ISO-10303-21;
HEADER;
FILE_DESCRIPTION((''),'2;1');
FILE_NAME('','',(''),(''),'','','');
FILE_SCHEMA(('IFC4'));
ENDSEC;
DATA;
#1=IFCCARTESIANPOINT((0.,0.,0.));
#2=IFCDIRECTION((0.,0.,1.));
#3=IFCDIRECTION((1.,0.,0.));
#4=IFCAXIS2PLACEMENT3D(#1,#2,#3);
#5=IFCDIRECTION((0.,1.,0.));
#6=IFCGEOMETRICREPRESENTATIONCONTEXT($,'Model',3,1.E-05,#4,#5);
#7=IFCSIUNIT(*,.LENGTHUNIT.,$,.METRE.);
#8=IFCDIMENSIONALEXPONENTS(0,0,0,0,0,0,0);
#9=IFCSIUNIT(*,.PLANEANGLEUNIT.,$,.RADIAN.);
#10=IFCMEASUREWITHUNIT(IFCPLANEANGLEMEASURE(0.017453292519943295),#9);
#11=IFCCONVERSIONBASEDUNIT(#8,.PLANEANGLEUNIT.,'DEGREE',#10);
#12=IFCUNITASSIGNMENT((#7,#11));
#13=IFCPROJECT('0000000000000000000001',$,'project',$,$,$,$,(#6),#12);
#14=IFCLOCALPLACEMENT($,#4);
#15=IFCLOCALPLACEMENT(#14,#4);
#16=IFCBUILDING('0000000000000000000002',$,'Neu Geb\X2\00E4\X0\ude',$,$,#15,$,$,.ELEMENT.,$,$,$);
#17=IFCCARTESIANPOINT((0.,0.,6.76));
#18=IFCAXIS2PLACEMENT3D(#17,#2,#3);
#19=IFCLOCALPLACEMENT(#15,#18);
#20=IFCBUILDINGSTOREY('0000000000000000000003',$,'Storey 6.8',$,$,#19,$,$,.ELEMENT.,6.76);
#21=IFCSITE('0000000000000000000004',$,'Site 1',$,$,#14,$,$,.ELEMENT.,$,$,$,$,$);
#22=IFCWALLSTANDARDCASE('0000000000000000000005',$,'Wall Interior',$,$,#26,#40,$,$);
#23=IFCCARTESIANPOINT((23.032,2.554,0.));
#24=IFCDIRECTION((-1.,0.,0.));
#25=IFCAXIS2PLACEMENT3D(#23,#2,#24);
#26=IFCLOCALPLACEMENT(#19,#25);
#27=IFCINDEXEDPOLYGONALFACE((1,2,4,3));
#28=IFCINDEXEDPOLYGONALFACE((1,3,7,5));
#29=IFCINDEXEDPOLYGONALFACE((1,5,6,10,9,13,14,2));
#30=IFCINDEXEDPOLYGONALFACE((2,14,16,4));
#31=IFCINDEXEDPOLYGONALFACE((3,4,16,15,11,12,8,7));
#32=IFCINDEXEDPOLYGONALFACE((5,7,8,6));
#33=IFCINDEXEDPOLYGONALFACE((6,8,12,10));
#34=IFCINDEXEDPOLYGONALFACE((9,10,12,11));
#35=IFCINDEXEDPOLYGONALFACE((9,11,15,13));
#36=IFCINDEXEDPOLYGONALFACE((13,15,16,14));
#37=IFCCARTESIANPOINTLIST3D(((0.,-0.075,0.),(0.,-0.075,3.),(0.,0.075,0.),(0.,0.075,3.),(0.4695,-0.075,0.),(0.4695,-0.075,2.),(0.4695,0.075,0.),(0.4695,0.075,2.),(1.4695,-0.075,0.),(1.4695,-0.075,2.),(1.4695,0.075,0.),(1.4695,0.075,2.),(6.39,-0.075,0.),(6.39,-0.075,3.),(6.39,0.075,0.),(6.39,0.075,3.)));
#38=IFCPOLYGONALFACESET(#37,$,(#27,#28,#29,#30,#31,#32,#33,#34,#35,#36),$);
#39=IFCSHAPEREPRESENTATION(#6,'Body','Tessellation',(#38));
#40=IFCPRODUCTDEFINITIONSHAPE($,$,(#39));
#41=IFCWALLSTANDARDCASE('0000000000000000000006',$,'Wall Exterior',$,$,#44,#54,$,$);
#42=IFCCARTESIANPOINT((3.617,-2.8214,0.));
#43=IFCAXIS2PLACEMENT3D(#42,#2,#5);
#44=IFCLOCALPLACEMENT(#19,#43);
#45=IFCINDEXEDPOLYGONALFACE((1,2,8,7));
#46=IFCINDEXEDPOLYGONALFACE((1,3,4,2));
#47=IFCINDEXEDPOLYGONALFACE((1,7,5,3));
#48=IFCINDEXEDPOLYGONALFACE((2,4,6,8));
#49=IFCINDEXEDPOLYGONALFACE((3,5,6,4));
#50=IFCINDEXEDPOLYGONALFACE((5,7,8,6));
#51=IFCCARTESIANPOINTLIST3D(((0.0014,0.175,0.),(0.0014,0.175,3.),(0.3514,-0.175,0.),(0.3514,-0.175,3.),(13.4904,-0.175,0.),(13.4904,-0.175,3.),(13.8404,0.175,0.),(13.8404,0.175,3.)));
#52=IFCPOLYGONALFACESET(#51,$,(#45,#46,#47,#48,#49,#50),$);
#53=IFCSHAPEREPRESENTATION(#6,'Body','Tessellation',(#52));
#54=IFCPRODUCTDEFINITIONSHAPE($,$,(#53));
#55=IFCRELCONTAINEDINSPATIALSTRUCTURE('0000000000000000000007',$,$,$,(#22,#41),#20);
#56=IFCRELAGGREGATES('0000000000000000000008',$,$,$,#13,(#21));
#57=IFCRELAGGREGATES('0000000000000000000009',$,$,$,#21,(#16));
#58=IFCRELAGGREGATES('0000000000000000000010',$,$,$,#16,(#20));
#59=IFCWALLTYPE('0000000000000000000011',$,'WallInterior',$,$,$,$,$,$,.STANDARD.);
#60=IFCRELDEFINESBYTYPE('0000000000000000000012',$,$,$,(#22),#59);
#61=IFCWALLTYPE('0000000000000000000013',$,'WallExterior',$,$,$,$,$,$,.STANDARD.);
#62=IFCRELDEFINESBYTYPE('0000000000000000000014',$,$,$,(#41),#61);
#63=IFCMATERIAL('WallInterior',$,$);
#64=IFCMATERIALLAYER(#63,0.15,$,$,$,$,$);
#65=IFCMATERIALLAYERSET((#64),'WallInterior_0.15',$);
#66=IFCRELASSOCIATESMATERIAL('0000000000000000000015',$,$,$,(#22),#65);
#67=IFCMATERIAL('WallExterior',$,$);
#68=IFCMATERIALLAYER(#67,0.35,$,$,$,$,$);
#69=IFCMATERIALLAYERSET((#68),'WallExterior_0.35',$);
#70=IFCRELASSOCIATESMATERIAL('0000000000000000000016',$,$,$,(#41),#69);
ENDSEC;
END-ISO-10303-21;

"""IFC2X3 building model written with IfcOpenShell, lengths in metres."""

from ifc_helpers import new_model, entity, si_unit, converted_unit, direction, frame, origin_with_axes, place, context, project, spatial, polyline, outline, extrude, material, layer, layer_set, layer_usage, type_object, element, save


model = new_model("IFC2X3")

# Units and contexts
model_context = context("Model", 3, precision=1e-05, world=origin_with_axes(), true_north=direction((0.0, 1.0, 0.0)))
ifc_project = project(units=[si_unit("LENGTHUNIT", "METRE"), converted_unit("PLANEANGLEUNIT", "DEGREE", entity("IfcPlaneAngleMeasure", 0.017453292519943295), si_unit("PLANEANGLEUNIT", "RADIAN"), dimensions=[0, 0, 0, 0, 0, 0, 0])], contexts=[model_context])

# Site, building, storey
site_placement = place(None, origin_with_axes())
site = spatial("IfcSite", under=ifc_project, at=site_placement, Name="Site 1", CompositionType="ELEMENT")
building_placement = place(site_placement, origin_with_axes())
building = spatial("IfcBuilding", under=site, at=building_placement, Name="Neu Gebäude", CompositionType="ELEMENT")
storey_placement = place(building_placement, frame((0.0, 0.0, 6.76), z_axis=(0.0, 0.0, 1.0), x_axis=(1.0, 0.0, 0.0)))
storey = spatial("IfcBuildingStorey", under=building, at=storey_placement, Name="Storey 6.8", CompositionType="ELEMENT", Elevation=6.76)

# Shared definitions
ifc_material_1 = material(Name="WallInterior")
wall_type_1 = type_object("IfcWallType", Name="WallInterior", PredefinedType="STANDARD")
ifc_layer_1 = layer(ifc_material_1, 0.15)
ifc_layer_set_1 = layer_set([ifc_layer_1], Name="WallInterior_0.15")
ifc_layer_usage_1 = layer_usage(ifc_layer_set_1, "AXIS2", "POSITIVE", -0.075)

# Wall, opening
wall_1_placement = place(storey_placement, frame((23.032, 2.554, 0.0), z_axis=(0.0, 0.0, 1.0), x_axis=(-1.0, 0.0, 0.0)))
wall_1 = element("IfcWallStandardCase", 1, at=wall_1_placement, inside=storey, type_object=wall_type_1, material=ifc_layer_usage_1, Name="Wall Interior", context=model_context, shape_type="SweptSolid", body=[
    extrude(outline(polyline([(0.0, -0.075), (6.39, -0.075), (6.39, 0.075), (0.0, 0.075), (0.0, -0.075)])), origin_with_axes(), (0.0, 0.0, 1.0), 3.0),
])
opening_1_placement = place(wall_1_placement, frame((0.9695, 0.0, 0.0), z_axis=(0.0, 0.0, 1.0), x_axis=(1.0, 0.0, 0.0)))
element("IfcOpeningElement", 2, at=opening_1_placement, cuts=wall_1, context=model_context, shape_type="SweptSolid", body=[
    extrude(outline(polyline([(-0.5, 0.172), (0.5, 0.172), (0.5, -0.172), (-0.5, -0.172), (-0.5, 0.172)])), origin_with_axes(), (0.0, 0.0, 1.0), 2.0),
])

# Shared definitions
ifc_material_2 = material(Name="WallExterior")
ifc_layer_2 = layer(ifc_material_2, 0.35)
ifc_layer_set_2 = layer_set([ifc_layer_2], Name="WallExterior_0.35")
ifc_layer_usage_2 = layer_usage(ifc_layer_set_2, "AXIS2", "POSITIVE", -0.175)
wall_type_2 = type_object("IfcWallType", Name="WallExterior", PredefinedType="STANDARD")

# Wall
wall_2_placement = place(storey_placement, frame((3.617, -2.8214, 0.0), z_axis=(0.0, 0.0, 1.0), x_axis=(0.0, 1.0, 0.0)))
element("IfcWallStandardCase", 3, at=wall_2_placement, inside=storey, type_object=wall_type_2, material=ifc_layer_usage_2, Name="Wall Exterior", context=model_context, shape_type="SweptSolid", body=[
    extrude(outline(polyline([(0.3514, -0.175), (13.4904, -0.175), (13.8404, 0.175), (0.0014, 0.175), (0.3514, -0.175)])), origin_with_axes(), (0.0, 0.0, 1.0), 3.0),
])

save(model, "model.ifc")
